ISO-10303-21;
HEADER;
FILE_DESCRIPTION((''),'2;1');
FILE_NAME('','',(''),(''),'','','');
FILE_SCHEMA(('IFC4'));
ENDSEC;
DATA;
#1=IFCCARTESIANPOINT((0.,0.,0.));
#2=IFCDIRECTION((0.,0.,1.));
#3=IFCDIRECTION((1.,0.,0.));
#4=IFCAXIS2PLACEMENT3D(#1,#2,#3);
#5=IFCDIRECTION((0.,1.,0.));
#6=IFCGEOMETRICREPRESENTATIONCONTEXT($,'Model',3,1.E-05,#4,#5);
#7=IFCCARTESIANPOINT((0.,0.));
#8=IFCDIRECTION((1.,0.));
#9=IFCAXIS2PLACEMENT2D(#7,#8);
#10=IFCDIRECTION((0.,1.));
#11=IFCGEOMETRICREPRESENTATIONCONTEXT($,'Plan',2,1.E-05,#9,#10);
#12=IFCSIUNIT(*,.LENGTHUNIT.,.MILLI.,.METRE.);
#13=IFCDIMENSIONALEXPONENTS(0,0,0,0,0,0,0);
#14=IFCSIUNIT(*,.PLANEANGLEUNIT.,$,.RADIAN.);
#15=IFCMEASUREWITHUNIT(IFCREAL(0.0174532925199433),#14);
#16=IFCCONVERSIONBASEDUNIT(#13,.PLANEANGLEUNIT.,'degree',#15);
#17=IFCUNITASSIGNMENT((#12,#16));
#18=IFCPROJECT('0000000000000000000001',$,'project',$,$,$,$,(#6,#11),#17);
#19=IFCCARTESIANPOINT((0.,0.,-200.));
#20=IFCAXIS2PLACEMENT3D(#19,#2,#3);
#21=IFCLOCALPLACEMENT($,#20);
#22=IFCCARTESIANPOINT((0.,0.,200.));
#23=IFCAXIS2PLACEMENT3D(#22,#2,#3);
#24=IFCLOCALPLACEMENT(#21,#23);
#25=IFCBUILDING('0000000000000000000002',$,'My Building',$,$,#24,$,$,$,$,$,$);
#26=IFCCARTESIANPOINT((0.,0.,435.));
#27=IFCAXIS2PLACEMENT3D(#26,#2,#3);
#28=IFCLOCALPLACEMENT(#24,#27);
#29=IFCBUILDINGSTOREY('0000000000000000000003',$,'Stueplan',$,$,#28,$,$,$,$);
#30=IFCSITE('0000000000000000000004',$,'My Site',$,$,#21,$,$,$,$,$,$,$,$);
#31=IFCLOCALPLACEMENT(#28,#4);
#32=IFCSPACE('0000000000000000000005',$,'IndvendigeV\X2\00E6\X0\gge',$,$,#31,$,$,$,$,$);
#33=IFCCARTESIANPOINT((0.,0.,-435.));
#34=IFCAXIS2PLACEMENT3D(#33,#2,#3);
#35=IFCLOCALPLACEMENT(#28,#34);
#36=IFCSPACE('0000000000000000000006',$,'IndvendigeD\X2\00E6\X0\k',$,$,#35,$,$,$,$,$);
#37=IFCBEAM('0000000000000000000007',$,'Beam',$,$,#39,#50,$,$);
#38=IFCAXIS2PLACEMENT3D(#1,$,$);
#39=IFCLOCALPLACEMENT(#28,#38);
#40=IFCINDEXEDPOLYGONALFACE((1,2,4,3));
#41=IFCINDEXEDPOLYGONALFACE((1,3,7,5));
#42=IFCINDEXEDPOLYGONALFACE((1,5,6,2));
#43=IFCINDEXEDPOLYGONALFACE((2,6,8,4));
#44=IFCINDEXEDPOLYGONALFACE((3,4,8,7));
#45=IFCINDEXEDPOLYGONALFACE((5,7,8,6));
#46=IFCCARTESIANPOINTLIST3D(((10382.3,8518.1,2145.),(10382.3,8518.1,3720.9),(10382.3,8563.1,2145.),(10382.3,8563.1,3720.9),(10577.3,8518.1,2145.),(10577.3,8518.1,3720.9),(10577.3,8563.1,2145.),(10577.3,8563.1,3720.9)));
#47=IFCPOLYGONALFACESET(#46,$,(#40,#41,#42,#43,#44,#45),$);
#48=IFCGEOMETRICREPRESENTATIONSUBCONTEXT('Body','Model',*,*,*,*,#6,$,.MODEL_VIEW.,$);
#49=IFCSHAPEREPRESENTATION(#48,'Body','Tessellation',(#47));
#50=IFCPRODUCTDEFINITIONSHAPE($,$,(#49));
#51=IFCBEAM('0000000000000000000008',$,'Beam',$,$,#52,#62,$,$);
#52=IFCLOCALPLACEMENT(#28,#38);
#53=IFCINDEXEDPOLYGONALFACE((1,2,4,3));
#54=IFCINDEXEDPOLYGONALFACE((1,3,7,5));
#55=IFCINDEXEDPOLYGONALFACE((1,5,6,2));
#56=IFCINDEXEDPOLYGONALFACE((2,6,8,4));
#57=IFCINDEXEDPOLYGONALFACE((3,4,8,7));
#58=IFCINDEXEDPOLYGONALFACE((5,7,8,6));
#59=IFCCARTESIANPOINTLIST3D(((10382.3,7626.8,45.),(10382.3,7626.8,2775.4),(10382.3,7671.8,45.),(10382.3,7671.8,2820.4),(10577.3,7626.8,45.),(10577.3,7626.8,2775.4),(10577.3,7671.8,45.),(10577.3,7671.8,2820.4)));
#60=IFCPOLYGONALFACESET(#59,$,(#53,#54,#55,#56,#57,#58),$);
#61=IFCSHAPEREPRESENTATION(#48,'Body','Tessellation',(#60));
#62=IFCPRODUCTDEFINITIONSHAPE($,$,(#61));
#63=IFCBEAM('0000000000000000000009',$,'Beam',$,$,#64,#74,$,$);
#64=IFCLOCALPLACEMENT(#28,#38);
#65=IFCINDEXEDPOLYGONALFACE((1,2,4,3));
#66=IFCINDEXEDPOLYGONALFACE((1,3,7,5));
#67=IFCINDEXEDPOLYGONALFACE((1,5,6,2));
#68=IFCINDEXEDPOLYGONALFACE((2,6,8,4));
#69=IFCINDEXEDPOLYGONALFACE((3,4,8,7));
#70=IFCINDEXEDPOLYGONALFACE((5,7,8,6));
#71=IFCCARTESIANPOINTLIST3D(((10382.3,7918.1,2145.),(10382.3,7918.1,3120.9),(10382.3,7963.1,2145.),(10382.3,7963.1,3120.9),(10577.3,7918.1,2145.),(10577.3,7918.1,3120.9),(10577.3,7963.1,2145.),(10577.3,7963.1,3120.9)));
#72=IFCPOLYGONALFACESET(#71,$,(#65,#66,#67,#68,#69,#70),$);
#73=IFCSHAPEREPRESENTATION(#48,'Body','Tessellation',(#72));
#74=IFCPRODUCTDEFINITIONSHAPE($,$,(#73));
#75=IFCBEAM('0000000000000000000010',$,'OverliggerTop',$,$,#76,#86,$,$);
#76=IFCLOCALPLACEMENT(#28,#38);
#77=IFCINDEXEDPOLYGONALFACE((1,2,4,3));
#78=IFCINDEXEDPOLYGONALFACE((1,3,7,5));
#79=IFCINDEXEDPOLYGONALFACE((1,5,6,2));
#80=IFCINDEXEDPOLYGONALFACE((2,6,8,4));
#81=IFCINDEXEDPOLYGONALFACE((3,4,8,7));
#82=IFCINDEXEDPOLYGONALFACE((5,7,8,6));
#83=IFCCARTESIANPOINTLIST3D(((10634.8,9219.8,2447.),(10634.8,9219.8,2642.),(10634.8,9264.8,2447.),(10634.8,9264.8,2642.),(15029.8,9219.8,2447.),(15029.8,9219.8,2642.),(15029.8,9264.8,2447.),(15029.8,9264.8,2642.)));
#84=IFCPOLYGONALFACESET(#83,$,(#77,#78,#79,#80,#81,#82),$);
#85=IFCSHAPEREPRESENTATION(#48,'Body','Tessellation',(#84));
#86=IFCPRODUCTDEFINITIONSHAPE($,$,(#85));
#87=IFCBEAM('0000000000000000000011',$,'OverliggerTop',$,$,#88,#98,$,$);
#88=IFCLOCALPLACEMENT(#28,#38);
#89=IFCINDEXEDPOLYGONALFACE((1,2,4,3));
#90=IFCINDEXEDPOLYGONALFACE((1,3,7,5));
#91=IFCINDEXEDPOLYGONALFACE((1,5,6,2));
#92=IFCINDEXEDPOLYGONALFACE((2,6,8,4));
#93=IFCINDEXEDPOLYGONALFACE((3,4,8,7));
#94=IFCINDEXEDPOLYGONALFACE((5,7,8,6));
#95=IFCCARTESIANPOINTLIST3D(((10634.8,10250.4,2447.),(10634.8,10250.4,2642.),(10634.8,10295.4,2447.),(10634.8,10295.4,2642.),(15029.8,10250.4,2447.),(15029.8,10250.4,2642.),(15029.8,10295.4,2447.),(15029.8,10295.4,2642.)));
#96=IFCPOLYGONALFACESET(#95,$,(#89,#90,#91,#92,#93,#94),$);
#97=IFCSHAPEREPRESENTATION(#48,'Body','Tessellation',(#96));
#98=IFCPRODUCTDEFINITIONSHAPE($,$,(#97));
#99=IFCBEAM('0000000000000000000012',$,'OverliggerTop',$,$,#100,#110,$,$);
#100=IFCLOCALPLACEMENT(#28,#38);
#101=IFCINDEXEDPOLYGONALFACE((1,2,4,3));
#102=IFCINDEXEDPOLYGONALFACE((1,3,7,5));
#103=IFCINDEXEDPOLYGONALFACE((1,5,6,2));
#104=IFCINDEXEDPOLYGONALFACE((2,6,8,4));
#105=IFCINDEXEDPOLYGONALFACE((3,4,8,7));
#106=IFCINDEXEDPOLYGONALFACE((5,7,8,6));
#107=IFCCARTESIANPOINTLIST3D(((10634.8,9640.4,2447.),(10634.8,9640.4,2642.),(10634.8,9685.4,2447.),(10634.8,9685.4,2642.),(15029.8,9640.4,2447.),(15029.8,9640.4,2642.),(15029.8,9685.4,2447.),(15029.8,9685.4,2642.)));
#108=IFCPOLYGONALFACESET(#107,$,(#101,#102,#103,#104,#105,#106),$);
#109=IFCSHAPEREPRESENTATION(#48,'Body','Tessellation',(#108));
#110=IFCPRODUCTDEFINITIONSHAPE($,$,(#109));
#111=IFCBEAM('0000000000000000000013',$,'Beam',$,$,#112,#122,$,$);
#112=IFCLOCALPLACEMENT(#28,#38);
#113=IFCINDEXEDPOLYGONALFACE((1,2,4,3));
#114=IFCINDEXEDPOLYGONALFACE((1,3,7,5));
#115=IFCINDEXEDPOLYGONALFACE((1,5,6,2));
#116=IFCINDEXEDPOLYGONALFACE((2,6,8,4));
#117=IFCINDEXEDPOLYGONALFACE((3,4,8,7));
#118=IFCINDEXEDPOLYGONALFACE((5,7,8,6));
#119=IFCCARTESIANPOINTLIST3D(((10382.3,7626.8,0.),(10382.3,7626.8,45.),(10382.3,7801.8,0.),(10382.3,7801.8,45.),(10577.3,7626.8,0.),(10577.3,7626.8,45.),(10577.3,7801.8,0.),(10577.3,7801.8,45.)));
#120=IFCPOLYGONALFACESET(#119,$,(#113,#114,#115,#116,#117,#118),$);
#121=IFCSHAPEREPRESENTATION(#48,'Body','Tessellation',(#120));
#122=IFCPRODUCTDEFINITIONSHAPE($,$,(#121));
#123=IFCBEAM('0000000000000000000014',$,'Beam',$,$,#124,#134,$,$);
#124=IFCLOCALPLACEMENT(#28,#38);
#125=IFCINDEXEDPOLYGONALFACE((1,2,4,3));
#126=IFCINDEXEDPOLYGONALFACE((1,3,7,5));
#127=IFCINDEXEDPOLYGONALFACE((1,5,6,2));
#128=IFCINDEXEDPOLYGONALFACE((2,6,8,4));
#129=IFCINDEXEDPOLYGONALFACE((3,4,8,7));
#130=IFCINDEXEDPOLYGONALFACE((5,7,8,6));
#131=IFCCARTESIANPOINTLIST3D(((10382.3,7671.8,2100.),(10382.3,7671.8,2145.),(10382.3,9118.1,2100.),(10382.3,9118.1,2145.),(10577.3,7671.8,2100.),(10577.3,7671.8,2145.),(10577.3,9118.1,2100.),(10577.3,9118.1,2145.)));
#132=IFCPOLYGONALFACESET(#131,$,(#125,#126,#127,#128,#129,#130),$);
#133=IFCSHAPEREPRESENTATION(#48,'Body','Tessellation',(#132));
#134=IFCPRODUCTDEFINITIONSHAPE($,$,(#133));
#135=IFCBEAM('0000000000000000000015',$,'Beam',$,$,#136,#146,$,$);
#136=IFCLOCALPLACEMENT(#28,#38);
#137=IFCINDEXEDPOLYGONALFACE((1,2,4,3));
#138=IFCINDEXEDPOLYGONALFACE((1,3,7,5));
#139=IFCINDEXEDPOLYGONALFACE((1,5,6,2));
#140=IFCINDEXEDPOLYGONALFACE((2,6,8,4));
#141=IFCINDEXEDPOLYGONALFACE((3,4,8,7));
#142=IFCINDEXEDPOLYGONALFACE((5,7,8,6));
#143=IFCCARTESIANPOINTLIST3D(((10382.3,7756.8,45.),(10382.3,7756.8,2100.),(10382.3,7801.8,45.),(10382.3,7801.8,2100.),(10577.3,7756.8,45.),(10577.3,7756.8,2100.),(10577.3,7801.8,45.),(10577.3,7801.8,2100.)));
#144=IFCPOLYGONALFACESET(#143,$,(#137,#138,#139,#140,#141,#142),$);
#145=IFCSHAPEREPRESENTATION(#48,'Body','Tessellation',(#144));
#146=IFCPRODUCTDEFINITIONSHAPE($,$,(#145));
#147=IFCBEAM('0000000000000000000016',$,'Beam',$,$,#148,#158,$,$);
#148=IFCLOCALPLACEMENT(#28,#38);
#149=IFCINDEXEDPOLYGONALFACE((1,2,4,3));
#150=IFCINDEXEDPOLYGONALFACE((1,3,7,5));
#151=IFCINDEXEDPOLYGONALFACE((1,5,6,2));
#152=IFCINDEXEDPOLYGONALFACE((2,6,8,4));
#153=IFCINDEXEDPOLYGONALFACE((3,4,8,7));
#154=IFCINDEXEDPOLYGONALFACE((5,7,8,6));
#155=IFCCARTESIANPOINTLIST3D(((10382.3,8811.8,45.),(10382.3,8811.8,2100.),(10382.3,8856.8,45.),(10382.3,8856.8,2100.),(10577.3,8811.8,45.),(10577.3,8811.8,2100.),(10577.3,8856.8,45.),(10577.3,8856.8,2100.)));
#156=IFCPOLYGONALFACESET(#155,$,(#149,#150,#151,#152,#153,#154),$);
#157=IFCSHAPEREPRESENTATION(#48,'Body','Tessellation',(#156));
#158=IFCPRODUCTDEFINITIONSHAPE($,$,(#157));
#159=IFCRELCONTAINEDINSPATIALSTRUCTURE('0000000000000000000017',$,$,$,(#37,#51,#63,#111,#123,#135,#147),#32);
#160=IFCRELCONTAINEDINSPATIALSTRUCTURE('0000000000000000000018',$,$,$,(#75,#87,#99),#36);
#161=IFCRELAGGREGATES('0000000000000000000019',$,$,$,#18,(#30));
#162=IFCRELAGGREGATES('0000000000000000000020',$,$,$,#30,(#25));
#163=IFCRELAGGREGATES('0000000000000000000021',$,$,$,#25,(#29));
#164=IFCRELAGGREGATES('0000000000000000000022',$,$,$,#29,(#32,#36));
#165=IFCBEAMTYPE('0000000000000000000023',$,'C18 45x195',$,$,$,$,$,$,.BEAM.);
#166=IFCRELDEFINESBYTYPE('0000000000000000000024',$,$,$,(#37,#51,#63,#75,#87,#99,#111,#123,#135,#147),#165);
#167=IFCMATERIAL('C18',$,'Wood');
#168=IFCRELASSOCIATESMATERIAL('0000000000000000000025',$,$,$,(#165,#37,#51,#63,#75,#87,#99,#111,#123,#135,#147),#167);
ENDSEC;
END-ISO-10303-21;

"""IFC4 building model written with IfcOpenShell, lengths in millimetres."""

from ifc_helpers import new_model, entity, si_unit, converted_unit, direction, frame, origin_with_axes, origin_2d_with_axis, place, context, subcontext, project, spatial, rectangle, extrude, clip, halfspace, material, material_profile, profile_set, profile_usage, type_object, element, save


model = new_model("IFC4")

# Units and contexts
model_context = context("Model", 3, precision=1e-05, world=origin_with_axes(), true_north=direction((0.0, 1.0, 0.0)))
plan_context = context("Plan", 2, precision=1e-05, world=origin_2d_with_axis(), true_north=direction((0.0, 1.0)))
body_context_1 = subcontext(model_context, "Body", "Model", "MODEL_VIEW")
ifc_project = project(units=[si_unit("LENGTHUNIT", "METRE", prefix="MILLI"), converted_unit("PLANEANGLEUNIT", "degree", entity("IfcReal", 0.0174532925199433), si_unit("PLANEANGLEUNIT", "RADIAN"), dimensions=[0, 0, 0, 0, 0, 0, 0])], contexts=[model_context, plan_context])

# Site, building, storey
site_placement = place(None, frame((0.0, 0.0, -200.0), z_axis=(0.0, 0.0, 1.0), x_axis=(1.0, 0.0, 0.0)))
site = spatial("IfcSite", under=ifc_project, at=site_placement, Name="My Site")
building_placement = place(site_placement, frame((0.0, 0.0, 200.0), z_axis=(0.0, 0.0, 1.0), x_axis=(1.0, 0.0, 0.0)))
building = spatial("IfcBuilding", under=site, at=building_placement, Name="My Building")
storey_placement = place(building_placement, frame((0.0, 0.0, 435.0), z_axis=(0.0, 0.0, 1.0), x_axis=(1.0, 0.0, 0.0)))
storey = spatial("IfcBuildingStorey", under=building, at=storey_placement, Name="Stueplan")

# Shared definitions
ifc_material = material(Name="C18", Category="Wood")

# Shared definitions
space_1_placement = place(storey_placement, frame((0.0, 0.0, 0.0), z_axis=(0.0, 0.0, 1.0), x_axis=(1.0, 0.0, 0.0)))
space_1 = spatial("IfcSpace", under=storey, at=space_1_placement, Name="IndvendigeVægge")

# Beams
ifc_material_profile_1 = material_profile(ifc_material, rectangle(XDim=45.0, YDim=195.0))
ifc_profile_set_1 = profile_set([ifc_material_profile_1], Name="woodStructural")
beam_type_1 = type_object("IfcBeamType", Name="C18 45x195", PredefinedType="BEAM", material=ifc_profile_set_1)
ifc_profile_usage_1 = profile_usage(ifc_profile_set_1)
beam_1_placement = place(space_1_placement, frame((10479.8, 8540.6, 2145.0), z_axis=(0.0, 0.0, 1.0), x_axis=(0.0, 1.0, 0.0)))
element("IfcBeam", 1, at=beam_1_placement, inside=space_1, type_object=beam_type_1, material=ifc_profile_usage_1, Name="Beam", context=body_context_1, shape_type="SweptSolid", body=[
    extrude(rectangle(XDim=45.0, YDim=195.0), origin_with_axes(), (0.0, 0.0, 1.0), 1575.9),
])
ifc_profile_usage_2 = profile_usage(ifc_profile_set_1)
beam_2_placement = place(space_1_placement, frame((10479.8, 7649.3, 45.0), z_axis=(0.0, 0.0, 1.0), x_axis=(0.0, 1.0, 0.0)))
element("IfcBeam", 2, at=beam_2_placement, inside=space_1, type_object=beam_type_1, material=ifc_profile_usage_2, Name="Beam", context=body_context_1, shape_type="Clipping", body=[
    clip(extrude(rectangle(XDim=45.0, YDim=195.0), origin_with_axes(), (0.0, 0.0, 1.0), 2947.9), halfspace(frame((-144.5, 0.0, 2608.4), z_axis=(-0.707107, 0.0, 0.707107), x_axis=(0.0, 1.0, 0.0)), False)),
])
ifc_profile_usage_3 = profile_usage(ifc_profile_set_1)
beam_3_placement = place(space_1_placement, frame((10479.8, 7940.6, 2145.0), z_axis=(0.0, 0.0, 1.0), x_axis=(0.0, 1.0, 0.0)))
element("IfcBeam", 3, at=beam_3_placement, inside=space_1, type_object=beam_type_1, material=ifc_profile_usage_3, Name="Beam", context=body_context_1, shape_type="SweptSolid", body=[
    extrude(rectangle(XDim=45.0, YDim=195.0), origin_with_axes(), (0.0, 0.0, 1.0), 975.9),
])

# Shared definitions
space_2_placement = place(storey_placement, frame((0.0, 0.0, -435.0), z_axis=(0.0, 0.0, 1.0), x_axis=(1.0, 0.0, 0.0)))
space_2 = spatial("IfcSpace", under=storey, at=space_2_placement, Name="IndvendigeDæk")

# Beams
ifc_profile_usage_4 = profile_usage(ifc_profile_set_1)
beam_4_placement = place(space_2_placement, frame((10634.8, 9242.3, 2979.5), z_axis=(1.0, 0.000001, 0.0), x_axis=(0.000001, -1.0, 0.0)))
element("IfcBeam", 4, at=beam_4_placement, inside=space_2, type_object=beam_type_1, material=ifc_profile_usage_4, Name="OverliggerTop", context=body_context_1, shape_type="SweptSolid", body=[
    extrude(rectangle(XDim=45.0, YDim=195.0), origin_with_axes(), (0.0, 0.0, 1.0), 4395.0),
])
ifc_profile_usage_5 = profile_usage(ifc_profile_set_1)
beam_5_placement = place(space_2_placement, frame((10634.8, 10272.9, 2979.5), z_axis=(1.0, 0.000001, 0.0), x_axis=(0.000001, -1.0, 0.0)))
element("IfcBeam", 5, at=beam_5_placement, inside=space_2, type_object=beam_type_1, material=ifc_profile_usage_5, Name="OverliggerTop", context=body_context_1, shape_type="SweptSolid", body=[
    extrude(rectangle(XDim=45.0, YDim=195.0), origin_with_axes(), (0.0, 0.0, 1.0), 4395.0),
])
ifc_profile_usage_6 = profile_usage(ifc_profile_set_1)
beam_6_placement = place(space_2_placement, frame((10634.8, 9662.9, 2979.5), z_axis=(1.0, 0.000001, 0.0), x_axis=(0.000001, -1.0, 0.0)))
element("IfcBeam", 6, at=beam_6_placement, inside=space_2, type_object=beam_type_1, material=ifc_profile_usage_6, Name="OverliggerTop", context=body_context_1, shape_type="SweptSolid", body=[
    extrude(rectangle(XDim=45.0, YDim=195.0), origin_with_axes(), (0.0, 0.0, 1.0), 4395.0),
])
ifc_profile_usage_7 = profile_usage(ifc_profile_set_1)
beam_7_placement = place(space_1_placement, frame((10479.8, 7801.8, 22.5), z_axis=(0.0, -1.0, 0.0), x_axis=(0.0, 0.0, 1.0)))
element("IfcBeam", 7, at=beam_7_placement, inside=space_1, type_object=beam_type_1, material=ifc_profile_usage_7, Name="Beam", context=body_context_1, shape_type="SweptSolid", body=[
    extrude(rectangle(XDim=45.0, YDim=195.0), origin_with_axes(), (0.0, 0.0, 1.0), 175.0),
])
ifc_profile_usage_8 = profile_usage(ifc_profile_set_1)
beam_8_placement = place(space_1_placement, frame((10479.8, 9118.1, 2122.5), z_axis=(0.0, -1.0, 0.0), x_axis=(0.0, 0.0, 1.0)))
element("IfcBeam", 8, at=beam_8_placement, inside=space_1, type_object=beam_type_1, material=ifc_profile_usage_8, Name="Beam", context=body_context_1, shape_type="SweptSolid", body=[
    extrude(rectangle(XDim=45.0, YDim=195.0), origin_with_axes(), (0.0, 0.0, 1.0), 1446.3),
])
ifc_profile_usage_9 = profile_usage(ifc_profile_set_1)
beam_9_placement = place(space_1_placement, frame((10479.8, 7779.3, 45.0), z_axis=(0.0, 0.0, 1.0), x_axis=(0.0, -1.0, 0.0)))
element("IfcBeam", 9, at=beam_9_placement, inside=space_1, type_object=beam_type_1, material=ifc_profile_usage_9, Name="Beam", context=body_context_1, shape_type="SweptSolid", body=[
    extrude(rectangle(XDim=45.0, YDim=195.0), origin_with_axes(), (0.0, 0.0, 1.0), 2055.0),
])
ifc_profile_usage_10 = profile_usage(ifc_profile_set_1)
beam_10_placement = place(space_1_placement, frame((10479.8, 8834.3, 45.0), z_axis=(0.0, 0.0, 1.0), x_axis=(0.0, -1.0, 0.0)))
element("IfcBeam", 10, at=beam_10_placement, inside=space_1, type_object=beam_type_1, material=ifc_profile_usage_10, Name="Beam", context=body_context_1, shape_type="SweptSolid", body=[
    extrude(rectangle(XDim=45.0, YDim=195.0), origin_with_axes(), (0.0, 0.0, 1.0), 2055.0),
])

save(model, "model.ifc")
